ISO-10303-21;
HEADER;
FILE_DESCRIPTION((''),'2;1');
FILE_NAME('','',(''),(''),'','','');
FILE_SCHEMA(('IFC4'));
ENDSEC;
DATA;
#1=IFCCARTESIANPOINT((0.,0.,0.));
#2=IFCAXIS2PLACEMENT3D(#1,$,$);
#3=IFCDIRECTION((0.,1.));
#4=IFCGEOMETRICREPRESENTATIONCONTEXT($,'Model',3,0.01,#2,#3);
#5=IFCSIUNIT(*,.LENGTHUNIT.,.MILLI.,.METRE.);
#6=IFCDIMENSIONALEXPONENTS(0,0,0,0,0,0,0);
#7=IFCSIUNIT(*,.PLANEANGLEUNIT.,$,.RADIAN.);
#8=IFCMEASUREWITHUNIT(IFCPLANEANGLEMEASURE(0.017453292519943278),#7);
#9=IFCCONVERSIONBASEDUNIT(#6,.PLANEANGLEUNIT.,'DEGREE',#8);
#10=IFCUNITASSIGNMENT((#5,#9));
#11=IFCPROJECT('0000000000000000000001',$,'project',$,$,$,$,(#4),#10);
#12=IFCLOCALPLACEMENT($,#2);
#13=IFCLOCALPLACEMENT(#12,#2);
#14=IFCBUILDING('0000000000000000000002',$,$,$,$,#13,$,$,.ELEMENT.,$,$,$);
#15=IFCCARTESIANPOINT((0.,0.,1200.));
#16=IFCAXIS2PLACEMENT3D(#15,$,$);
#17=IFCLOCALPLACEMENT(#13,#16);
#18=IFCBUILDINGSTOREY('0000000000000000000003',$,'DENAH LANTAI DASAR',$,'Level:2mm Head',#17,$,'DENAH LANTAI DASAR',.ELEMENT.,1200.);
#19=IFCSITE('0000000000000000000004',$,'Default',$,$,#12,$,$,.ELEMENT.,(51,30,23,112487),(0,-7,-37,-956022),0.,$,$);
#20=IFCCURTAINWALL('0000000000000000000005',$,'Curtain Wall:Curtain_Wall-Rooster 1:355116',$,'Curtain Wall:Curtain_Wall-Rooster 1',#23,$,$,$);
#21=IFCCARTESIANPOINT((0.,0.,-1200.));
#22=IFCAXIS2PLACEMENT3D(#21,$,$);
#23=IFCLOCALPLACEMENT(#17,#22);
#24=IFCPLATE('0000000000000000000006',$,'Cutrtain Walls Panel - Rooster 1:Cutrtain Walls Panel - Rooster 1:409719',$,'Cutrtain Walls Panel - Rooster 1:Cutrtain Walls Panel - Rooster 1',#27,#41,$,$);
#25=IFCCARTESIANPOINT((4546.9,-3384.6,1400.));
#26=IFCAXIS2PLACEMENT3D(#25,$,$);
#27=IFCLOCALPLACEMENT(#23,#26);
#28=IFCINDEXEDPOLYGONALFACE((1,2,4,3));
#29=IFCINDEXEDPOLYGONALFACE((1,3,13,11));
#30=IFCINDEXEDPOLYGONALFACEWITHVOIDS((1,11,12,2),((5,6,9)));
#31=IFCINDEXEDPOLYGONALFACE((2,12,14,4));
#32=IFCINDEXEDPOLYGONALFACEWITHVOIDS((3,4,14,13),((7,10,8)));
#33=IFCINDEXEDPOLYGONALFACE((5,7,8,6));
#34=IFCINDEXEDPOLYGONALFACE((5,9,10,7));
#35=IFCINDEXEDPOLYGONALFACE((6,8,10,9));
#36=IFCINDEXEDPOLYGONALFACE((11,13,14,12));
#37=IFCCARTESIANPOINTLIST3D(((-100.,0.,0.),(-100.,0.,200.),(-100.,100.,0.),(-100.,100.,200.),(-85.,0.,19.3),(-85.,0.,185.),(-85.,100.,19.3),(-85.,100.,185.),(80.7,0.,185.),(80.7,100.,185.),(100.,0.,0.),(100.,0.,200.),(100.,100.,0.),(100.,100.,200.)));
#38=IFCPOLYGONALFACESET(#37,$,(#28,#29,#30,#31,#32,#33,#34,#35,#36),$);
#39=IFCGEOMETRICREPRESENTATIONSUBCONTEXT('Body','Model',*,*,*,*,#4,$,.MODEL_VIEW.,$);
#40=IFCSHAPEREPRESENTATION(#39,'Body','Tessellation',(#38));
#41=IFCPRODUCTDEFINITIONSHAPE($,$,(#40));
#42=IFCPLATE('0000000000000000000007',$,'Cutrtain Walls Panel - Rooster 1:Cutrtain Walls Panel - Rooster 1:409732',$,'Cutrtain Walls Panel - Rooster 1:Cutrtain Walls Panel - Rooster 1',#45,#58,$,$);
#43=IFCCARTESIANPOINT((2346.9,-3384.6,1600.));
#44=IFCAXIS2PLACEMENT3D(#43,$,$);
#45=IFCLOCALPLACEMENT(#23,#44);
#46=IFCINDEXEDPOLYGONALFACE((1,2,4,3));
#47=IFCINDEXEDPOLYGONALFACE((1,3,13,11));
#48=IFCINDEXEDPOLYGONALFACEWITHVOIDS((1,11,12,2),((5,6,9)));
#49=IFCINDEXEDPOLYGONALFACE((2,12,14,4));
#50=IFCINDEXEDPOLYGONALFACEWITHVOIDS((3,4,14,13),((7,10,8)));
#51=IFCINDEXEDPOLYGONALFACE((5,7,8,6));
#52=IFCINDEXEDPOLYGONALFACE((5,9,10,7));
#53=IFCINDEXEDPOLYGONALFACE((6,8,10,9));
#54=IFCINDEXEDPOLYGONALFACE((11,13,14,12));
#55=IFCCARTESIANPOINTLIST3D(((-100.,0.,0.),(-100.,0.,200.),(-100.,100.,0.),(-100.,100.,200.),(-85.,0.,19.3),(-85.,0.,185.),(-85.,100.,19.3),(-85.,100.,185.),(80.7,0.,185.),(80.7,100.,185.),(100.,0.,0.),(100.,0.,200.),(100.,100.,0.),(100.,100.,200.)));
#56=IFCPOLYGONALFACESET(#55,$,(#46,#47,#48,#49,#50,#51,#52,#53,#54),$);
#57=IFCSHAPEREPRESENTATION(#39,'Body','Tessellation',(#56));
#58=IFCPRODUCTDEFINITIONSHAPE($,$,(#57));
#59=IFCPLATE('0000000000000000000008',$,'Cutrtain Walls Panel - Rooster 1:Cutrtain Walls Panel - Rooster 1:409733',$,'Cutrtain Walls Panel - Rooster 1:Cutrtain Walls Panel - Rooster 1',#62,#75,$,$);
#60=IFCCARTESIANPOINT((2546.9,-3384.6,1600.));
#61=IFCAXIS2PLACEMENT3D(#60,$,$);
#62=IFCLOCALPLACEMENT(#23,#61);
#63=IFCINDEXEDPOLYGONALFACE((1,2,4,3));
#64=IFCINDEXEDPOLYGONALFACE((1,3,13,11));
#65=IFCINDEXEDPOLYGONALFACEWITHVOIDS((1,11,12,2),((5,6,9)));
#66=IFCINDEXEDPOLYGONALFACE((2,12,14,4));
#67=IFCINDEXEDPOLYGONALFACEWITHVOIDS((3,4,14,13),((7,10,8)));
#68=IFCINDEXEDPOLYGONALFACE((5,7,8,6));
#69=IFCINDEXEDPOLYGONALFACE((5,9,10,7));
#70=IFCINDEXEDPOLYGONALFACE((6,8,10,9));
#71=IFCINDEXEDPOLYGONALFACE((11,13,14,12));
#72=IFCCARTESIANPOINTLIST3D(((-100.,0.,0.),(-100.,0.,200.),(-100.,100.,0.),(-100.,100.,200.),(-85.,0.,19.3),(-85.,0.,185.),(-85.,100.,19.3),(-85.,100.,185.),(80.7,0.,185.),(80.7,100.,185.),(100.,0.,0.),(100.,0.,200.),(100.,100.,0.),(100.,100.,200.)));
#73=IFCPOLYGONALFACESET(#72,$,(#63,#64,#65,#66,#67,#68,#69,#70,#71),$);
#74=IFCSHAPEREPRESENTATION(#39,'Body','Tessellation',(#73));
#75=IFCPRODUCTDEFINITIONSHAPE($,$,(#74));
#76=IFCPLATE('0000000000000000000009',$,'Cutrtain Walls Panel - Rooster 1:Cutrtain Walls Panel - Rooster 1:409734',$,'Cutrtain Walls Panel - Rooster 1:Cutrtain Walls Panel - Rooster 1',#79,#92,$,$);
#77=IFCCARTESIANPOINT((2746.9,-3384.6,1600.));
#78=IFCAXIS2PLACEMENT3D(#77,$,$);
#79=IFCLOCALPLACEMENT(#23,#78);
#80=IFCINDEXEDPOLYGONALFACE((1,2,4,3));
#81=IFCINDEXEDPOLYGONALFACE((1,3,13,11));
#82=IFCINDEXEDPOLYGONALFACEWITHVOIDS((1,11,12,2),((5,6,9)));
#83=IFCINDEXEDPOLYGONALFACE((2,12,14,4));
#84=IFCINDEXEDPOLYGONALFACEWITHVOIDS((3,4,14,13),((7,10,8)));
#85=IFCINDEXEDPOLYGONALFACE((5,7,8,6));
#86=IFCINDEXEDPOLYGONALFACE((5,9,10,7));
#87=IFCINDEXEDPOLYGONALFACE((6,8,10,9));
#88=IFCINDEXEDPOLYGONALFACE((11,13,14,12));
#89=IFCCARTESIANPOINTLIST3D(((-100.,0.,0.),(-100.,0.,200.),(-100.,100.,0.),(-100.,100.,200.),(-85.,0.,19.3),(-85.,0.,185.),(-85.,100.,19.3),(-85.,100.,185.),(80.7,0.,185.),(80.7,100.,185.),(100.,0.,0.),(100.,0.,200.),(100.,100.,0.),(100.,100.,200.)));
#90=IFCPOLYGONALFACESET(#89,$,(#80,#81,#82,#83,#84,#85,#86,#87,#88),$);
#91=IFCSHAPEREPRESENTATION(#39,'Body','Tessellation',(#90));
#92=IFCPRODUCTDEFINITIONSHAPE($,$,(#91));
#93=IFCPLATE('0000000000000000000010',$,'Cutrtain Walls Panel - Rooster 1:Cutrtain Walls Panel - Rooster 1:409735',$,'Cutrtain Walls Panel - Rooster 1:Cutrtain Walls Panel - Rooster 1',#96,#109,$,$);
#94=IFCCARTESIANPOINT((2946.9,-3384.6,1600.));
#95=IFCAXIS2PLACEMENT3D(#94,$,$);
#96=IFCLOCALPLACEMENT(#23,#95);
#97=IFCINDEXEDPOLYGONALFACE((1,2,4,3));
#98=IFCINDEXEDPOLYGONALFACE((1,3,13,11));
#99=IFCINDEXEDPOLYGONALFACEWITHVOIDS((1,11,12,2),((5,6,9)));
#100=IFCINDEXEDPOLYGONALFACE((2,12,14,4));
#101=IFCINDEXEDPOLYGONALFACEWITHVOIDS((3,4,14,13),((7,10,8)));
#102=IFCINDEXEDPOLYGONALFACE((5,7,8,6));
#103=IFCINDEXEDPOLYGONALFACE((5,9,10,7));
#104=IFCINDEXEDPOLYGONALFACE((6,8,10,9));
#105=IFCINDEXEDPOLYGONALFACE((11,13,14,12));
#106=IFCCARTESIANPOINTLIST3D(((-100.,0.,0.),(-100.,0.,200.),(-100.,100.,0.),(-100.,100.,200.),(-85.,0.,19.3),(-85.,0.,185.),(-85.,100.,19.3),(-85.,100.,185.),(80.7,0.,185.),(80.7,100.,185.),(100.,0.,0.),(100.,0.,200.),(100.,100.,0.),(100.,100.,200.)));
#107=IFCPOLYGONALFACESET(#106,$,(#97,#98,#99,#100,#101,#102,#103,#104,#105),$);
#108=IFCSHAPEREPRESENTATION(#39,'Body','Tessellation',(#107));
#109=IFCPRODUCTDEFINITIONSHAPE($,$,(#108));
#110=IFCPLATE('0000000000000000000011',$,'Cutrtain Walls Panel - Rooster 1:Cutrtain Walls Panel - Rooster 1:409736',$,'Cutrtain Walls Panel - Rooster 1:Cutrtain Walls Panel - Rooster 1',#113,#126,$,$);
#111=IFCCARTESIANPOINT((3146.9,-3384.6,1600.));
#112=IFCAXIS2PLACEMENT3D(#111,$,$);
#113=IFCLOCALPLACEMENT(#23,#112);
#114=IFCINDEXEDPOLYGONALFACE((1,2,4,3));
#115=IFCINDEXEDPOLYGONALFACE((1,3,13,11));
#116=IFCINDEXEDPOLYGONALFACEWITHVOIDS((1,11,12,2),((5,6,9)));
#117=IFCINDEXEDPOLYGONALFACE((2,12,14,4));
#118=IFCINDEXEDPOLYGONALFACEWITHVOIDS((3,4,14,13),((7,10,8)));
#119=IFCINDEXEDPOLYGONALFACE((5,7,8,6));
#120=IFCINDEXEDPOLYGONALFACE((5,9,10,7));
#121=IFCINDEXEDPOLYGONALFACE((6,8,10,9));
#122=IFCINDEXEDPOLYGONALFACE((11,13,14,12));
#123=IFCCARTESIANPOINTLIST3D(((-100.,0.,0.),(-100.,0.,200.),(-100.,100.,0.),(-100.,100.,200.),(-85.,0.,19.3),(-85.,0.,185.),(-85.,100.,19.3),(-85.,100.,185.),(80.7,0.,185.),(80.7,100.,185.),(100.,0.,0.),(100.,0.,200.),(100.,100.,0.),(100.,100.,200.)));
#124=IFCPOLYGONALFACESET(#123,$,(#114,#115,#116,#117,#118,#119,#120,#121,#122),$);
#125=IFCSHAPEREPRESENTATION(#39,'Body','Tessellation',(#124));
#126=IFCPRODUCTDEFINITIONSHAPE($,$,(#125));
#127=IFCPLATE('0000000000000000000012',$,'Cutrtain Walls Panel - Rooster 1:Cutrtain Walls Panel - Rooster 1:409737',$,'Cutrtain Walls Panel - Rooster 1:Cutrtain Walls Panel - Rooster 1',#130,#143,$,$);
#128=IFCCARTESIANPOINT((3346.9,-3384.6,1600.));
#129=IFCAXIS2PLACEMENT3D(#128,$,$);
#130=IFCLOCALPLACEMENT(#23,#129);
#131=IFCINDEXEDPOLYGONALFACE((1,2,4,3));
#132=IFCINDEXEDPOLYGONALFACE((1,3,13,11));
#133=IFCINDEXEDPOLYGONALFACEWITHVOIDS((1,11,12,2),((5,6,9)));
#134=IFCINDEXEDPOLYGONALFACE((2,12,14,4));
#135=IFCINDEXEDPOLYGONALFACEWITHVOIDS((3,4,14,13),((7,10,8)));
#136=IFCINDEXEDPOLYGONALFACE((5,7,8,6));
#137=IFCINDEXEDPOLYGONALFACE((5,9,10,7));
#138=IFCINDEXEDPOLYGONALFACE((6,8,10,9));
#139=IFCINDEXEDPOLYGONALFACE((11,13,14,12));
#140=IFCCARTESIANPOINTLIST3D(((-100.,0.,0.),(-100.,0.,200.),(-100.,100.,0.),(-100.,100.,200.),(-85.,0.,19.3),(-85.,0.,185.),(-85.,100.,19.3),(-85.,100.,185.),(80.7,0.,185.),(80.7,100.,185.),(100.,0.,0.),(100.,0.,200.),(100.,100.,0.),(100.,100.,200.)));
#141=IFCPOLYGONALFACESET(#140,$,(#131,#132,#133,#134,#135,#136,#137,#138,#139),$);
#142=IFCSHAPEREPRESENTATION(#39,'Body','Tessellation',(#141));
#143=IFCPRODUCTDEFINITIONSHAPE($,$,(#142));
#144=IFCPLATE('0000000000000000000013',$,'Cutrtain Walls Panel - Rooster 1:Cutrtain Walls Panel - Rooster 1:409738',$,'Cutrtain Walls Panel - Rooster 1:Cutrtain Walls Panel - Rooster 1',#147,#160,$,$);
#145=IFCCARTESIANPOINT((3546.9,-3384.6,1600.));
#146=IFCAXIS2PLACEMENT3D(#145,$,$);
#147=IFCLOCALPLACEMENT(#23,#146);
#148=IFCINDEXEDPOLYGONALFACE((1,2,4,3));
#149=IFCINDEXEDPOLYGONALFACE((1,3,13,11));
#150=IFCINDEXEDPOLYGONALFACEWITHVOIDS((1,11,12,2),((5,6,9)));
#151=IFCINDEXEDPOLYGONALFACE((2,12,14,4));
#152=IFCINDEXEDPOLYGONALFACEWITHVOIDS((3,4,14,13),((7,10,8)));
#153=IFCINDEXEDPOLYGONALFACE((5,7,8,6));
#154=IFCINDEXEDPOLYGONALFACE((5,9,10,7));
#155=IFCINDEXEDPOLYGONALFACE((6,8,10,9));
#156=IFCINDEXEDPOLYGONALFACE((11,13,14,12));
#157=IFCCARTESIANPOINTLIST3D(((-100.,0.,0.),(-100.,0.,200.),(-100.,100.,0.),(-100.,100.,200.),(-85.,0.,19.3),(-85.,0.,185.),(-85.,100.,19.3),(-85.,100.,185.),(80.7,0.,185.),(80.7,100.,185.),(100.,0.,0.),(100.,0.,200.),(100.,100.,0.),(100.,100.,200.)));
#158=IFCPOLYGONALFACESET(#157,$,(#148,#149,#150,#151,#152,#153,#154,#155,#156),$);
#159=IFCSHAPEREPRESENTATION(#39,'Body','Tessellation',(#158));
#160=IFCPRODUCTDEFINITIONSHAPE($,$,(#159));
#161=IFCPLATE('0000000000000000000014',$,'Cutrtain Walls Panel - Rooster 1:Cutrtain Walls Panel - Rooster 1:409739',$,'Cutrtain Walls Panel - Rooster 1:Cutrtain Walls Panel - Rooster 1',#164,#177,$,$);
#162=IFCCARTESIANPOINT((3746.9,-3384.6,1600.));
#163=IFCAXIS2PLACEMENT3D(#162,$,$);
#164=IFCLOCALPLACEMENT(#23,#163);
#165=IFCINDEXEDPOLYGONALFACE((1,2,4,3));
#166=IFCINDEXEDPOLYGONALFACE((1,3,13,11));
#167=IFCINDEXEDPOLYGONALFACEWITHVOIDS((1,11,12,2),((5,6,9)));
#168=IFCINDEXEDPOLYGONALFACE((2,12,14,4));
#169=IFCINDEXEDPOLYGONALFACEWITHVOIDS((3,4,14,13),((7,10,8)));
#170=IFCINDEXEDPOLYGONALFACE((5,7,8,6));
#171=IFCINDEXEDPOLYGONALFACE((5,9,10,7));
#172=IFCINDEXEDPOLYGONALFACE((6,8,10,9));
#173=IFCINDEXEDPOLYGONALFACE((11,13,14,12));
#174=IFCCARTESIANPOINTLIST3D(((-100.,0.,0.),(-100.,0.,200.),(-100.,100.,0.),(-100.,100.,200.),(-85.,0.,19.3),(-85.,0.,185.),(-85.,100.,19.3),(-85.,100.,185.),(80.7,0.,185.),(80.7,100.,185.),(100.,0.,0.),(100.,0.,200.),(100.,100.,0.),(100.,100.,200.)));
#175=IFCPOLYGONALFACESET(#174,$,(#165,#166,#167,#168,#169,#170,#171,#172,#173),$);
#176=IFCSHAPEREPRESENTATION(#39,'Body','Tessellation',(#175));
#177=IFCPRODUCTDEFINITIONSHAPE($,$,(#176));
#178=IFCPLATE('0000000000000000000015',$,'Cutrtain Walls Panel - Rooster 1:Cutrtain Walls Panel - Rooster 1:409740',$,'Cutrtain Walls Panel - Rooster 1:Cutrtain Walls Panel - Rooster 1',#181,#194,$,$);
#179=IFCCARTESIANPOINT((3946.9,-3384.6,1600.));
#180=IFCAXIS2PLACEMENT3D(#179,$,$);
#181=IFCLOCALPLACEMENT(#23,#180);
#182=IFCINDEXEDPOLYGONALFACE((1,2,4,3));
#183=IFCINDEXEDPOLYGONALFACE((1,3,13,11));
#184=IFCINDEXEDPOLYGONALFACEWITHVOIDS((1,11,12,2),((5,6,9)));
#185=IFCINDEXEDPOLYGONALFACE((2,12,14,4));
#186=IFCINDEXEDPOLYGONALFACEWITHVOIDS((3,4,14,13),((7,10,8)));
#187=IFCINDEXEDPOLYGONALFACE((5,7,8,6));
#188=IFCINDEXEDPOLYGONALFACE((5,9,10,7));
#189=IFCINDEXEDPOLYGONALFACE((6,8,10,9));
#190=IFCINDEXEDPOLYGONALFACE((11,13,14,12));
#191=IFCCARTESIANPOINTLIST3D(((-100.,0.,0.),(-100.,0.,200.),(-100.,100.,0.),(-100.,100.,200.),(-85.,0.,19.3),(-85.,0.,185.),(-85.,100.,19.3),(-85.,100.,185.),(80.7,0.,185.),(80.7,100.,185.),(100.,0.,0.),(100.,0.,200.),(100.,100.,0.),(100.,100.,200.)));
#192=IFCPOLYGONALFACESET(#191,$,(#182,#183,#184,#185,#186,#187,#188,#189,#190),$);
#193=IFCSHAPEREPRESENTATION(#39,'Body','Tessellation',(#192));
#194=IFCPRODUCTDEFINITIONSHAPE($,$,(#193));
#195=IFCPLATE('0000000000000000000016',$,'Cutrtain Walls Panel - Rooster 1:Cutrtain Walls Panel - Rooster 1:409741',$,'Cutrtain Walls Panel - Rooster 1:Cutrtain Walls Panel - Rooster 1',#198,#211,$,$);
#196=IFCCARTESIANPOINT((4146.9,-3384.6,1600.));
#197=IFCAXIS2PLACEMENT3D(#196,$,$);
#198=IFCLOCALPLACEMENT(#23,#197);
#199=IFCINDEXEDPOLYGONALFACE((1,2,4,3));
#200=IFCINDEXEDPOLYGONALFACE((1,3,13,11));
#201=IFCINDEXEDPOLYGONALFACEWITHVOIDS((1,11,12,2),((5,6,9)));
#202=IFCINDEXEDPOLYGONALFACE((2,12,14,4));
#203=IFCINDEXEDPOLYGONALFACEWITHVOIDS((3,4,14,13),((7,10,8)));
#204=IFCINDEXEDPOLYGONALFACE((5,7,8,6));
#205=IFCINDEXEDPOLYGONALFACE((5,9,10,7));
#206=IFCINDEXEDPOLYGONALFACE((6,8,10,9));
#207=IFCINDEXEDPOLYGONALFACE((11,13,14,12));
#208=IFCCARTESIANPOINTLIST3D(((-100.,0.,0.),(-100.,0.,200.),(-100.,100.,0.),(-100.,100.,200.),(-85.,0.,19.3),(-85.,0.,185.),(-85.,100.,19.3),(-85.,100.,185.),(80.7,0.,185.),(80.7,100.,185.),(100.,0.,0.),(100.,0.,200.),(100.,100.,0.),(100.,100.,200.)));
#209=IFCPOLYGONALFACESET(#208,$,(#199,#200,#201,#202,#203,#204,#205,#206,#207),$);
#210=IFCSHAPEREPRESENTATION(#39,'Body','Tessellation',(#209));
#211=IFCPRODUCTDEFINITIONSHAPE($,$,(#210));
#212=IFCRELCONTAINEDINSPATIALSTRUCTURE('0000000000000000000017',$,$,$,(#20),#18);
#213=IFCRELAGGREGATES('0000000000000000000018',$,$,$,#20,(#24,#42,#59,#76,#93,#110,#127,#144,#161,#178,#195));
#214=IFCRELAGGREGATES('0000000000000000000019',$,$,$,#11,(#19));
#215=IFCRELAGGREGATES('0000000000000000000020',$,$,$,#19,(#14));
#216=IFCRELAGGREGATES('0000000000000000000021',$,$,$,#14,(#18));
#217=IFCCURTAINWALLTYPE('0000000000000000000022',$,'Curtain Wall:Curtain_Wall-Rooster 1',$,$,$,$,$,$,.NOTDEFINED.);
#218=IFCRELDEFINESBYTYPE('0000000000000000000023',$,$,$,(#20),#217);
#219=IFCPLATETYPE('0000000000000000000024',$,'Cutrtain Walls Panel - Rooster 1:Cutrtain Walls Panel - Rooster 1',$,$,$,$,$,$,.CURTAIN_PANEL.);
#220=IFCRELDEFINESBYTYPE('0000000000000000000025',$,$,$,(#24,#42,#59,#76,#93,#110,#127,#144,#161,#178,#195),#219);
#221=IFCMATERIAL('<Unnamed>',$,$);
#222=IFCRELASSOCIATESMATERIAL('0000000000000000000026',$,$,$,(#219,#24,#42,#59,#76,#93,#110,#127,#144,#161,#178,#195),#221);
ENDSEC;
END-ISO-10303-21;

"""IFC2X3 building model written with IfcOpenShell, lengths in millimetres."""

from ifc_helpers import new_model, entity, si_unit, converted_unit, direction, frame, origin, place, context, subcontext, project, spatial, polyline, outline, extrude, source, transform, mapped, material, type_object, type_shapes, element, aggregate, save


model = new_model("IFC2X3")

# Units and contexts
model_context = context("Model", 3, precision=0.01, world=origin(), true_north=direction((0.0, 1.0)))
body_context = subcontext(model_context, "Body", "Model", "MODEL_VIEW")
ifc_project = project(units=[si_unit("LENGTHUNIT", "METRE", prefix="MILLI"), converted_unit("PLANEANGLEUNIT", "DEGREE", entity("IfcPlaneAngleMeasure", 0.017453292519943278), si_unit("PLANEANGLEUNIT", "RADIAN"), dimensions=[0, 0, 0, 0, 0, 0, 0])], contexts=[model_context])

# Site, building, storey
site_placement = place(None, origin())
site = spatial("IfcSite", under=ifc_project, at=site_placement, Name="Default", CompositionType="ELEMENT", RefLatitude=(51, 30, 23, 112487), RefLongitude=(0, -7, -37, -956022), RefElevation=0.0)
building_placement = place(site_placement, origin())
building = spatial("IfcBuilding", under=site, at=building_placement, CompositionType="ELEMENT")
storey_placement = place(building_placement, frame((0.0, 0.0, 1200.0)))
storey = spatial("IfcBuildingStorey", under=building, at=storey_placement, Name="DENAH LANTAI DASAR", ObjectType="Level:2mm Head", LongName="DENAH LANTAI DASAR", CompositionType="ELEMENT", Elevation=1200.0)

# Curtain wall, plates
curtain_wall_type = type_object("IfcCurtainWallType", Name="Curtain Wall:Curtain_Wall-Rooster 1", PredefinedType="NOTDEFINED")
curtain_wall_placement = place(storey_placement, frame((0.0, 0.0, -1200.0)))
curtain_wall = element("IfcCurtainWall", 1, at=curtain_wall_placement, inside=storey, type_object=curtain_wall_type, Name="Curtain Wall:Curtain_Wall-Rooster 1:355116", ObjectType="Curtain Wall:Curtain_Wall-Rooster 1")
ifc_material = material(Name="<Unnamed>")
plate_type_1 = type_object("IfcPlateType", Name="Cutrtain Walls Panel - Rooster 1:Cutrtain Walls Panel - Rooster 1", PredefinedType="CURTAIN_PANEL", material=ifc_material)
shared_shape_1 = source(origin(), body_context, "Body", "SweptSolid", [
    extrude(outline(polyline([(-100.0, -100.0), (100.0, -100.0), (100.0, 100.0), (-100.0, 100.0), (-100.0, -100.0)]), holes=[polyline([(80.7, 85.0), (-85.0, -80.7), (-85.0, 85.0), (80.7, 85.0)])]), frame((0.0, 0.0, 100.0), z_axis=(0.0, 1.0, 0.0), x_axis=(0.0, 0.0, -1.0)), (0.0, 0.0, 1.0), 100.0),
])
type_shapes(plate_type_1, [shared_shape_1])
plate_1_placement = place(curtain_wall_placement, frame((4546.9, -3384.6, 1400.0)))
plate_1 = element("IfcPlate", 2, at=plate_1_placement, type_object=plate_type_1, material=ifc_material, Name="Cutrtain Walls Panel - Rooster 1:Cutrtain Walls Panel - Rooster 1:409719", ObjectType="Cutrtain Walls Panel - Rooster 1:Cutrtain Walls Panel - Rooster 1", context=body_context, shape_type="MappedRepresentation", body=[
    mapped(shared_shape_1, transform((0.0, 0.0, 0.0), scale=1.0)),
])
plate_2_placement = place(curtain_wall_placement, frame((2346.9, -3384.6, 1600.0)))
plate_2 = element("IfcPlate", 3, at=plate_2_placement, type_object=plate_type_1, material=ifc_material, Name="Cutrtain Walls Panel - Rooster 1:Cutrtain Walls Panel - Rooster 1:409732", ObjectType="Cutrtain Walls Panel - Rooster 1:Cutrtain Walls Panel - Rooster 1", context=body_context, shape_type="MappedRepresentation", body=[
    mapped(shared_shape_1, transform((0.0, 0.0, 0.0), scale=1.0)),
])
plate_3_placement = place(curtain_wall_placement, frame((2546.9, -3384.6, 1600.0)))
plate_3 = element("IfcPlate", 4, at=plate_3_placement, type_object=plate_type_1, material=ifc_material, Name="Cutrtain Walls Panel - Rooster 1:Cutrtain Walls Panel - Rooster 1:409733", ObjectType="Cutrtain Walls Panel - Rooster 1:Cutrtain Walls Panel - Rooster 1", context=body_context, shape_type="MappedRepresentation", body=[
    mapped(shared_shape_1, transform((0.0, 0.0, 0.0), scale=1.0)),
])
plate_4_placement = place(curtain_wall_placement, frame((2746.9, -3384.6, 1600.0)))
plate_4 = element("IfcPlate", 5, at=plate_4_placement, type_object=plate_type_1, material=ifc_material, Name="Cutrtain Walls Panel - Rooster 1:Cutrtain Walls Panel - Rooster 1:409734", ObjectType="Cutrtain Walls Panel - Rooster 1:Cutrtain Walls Panel - Rooster 1", context=body_context, shape_type="MappedRepresentation", body=[
    mapped(shared_shape_1, transform((0.0, 0.0, 0.0), scale=1.0)),
])
plate_5_placement = place(curtain_wall_placement, frame((2946.9, -3384.6, 1600.0)))
plate_5 = element("IfcPlate", 6, at=plate_5_placement, type_object=plate_type_1, material=ifc_material, Name="Cutrtain Walls Panel - Rooster 1:Cutrtain Walls Panel - Rooster 1:409735", ObjectType="Cutrtain Walls Panel - Rooster 1:Cutrtain Walls Panel - Rooster 1", context=body_context, shape_type="MappedRepresentation", body=[
    mapped(shared_shape_1, transform((0.0, 0.0, 0.0), scale=1.0)),
])
plate_6_placement = place(curtain_wall_placement, frame((3146.9, -3384.6, 1600.0)))
plate_6 = element("IfcPlate", 7, at=plate_6_placement, type_object=plate_type_1, material=ifc_material, Name="Cutrtain Walls Panel - Rooster 1:Cutrtain Walls Panel - Rooster 1:409736", ObjectType="Cutrtain Walls Panel - Rooster 1:Cutrtain Walls Panel - Rooster 1", context=body_context, shape_type="MappedRepresentation", body=[
    mapped(shared_shape_1, transform((0.0, 0.0, 0.0), scale=1.0)),
])
plate_7_placement = place(curtain_wall_placement, frame((3346.9, -3384.6, 1600.0)))
plate_7 = element("IfcPlate", 8, at=plate_7_placement, type_object=plate_type_1, material=ifc_material, Name="Cutrtain Walls Panel - Rooster 1:Cutrtain Walls Panel - Rooster 1:409737", ObjectType="Cutrtain Walls Panel - Rooster 1:Cutrtain Walls Panel - Rooster 1", context=body_context, shape_type="MappedRepresentation", body=[
    mapped(shared_shape_1, transform((0.0, 0.0, 0.0), scale=1.0)),
])
plate_8_placement = place(curtain_wall_placement, frame((3546.9, -3384.6, 1600.0)))
plate_8 = element("IfcPlate", 9, at=plate_8_placement, type_object=plate_type_1, material=ifc_material, Name="Cutrtain Walls Panel - Rooster 1:Cutrtain Walls Panel - Rooster 1:409738", ObjectType="Cutrtain Walls Panel - Rooster 1:Cutrtain Walls Panel - Rooster 1", context=body_context, shape_type="MappedRepresentation", body=[
    mapped(shared_shape_1, transform((0.0, 0.0, 0.0), scale=1.0)),
])
plate_9_placement = place(curtain_wall_placement, frame((3746.9, -3384.6, 1600.0)))
plate_9 = element("IfcPlate", 10, at=plate_9_placement, type_object=plate_type_1, material=ifc_material, Name="Cutrtain Walls Panel - Rooster 1:Cutrtain Walls Panel - Rooster 1:409739", ObjectType="Cutrtain Walls Panel - Rooster 1:Cutrtain Walls Panel - Rooster 1", context=body_context, shape_type="MappedRepresentation", body=[
    mapped(shared_shape_1, transform((0.0, 0.0, 0.0), scale=1.0)),
])
plate_10_placement = place(curtain_wall_placement, frame((3946.9, -3384.6, 1600.0)))
plate_10 = element("IfcPlate", 11, at=plate_10_placement, type_object=plate_type_1, material=ifc_material, Name="Cutrtain Walls Panel - Rooster 1:Cutrtain Walls Panel - Rooster 1:409740", ObjectType="Cutrtain Walls Panel - Rooster 1:Cutrtain Walls Panel - Rooster 1", context=body_context, shape_type="MappedRepresentation", body=[
    mapped(shared_shape_1, transform((0.0, 0.0, 0.0), scale=1.0)),
])
plate_11_placement = place(curtain_wall_placement, frame((4146.9, -3384.6, 1600.0)))
plate_11 = element("IfcPlate", 12, at=plate_11_placement, type_object=plate_type_1, material=ifc_material, Name="Cutrtain Walls Panel - Rooster 1:Cutrtain Walls Panel - Rooster 1:409741", ObjectType="Cutrtain Walls Panel - Rooster 1:Cutrtain Walls Panel - Rooster 1", context=body_context, shape_type="MappedRepresentation", body=[
    mapped(shared_shape_1, transform((0.0, 0.0, 0.0), scale=1.0)),
])
aggregate(curtain_wall, [plate_1, plate_2, plate_3, plate_4, plate_5, plate_6, plate_7, plate_8, plate_9, plate_10, plate_11])

save(model, "model.ifc")
